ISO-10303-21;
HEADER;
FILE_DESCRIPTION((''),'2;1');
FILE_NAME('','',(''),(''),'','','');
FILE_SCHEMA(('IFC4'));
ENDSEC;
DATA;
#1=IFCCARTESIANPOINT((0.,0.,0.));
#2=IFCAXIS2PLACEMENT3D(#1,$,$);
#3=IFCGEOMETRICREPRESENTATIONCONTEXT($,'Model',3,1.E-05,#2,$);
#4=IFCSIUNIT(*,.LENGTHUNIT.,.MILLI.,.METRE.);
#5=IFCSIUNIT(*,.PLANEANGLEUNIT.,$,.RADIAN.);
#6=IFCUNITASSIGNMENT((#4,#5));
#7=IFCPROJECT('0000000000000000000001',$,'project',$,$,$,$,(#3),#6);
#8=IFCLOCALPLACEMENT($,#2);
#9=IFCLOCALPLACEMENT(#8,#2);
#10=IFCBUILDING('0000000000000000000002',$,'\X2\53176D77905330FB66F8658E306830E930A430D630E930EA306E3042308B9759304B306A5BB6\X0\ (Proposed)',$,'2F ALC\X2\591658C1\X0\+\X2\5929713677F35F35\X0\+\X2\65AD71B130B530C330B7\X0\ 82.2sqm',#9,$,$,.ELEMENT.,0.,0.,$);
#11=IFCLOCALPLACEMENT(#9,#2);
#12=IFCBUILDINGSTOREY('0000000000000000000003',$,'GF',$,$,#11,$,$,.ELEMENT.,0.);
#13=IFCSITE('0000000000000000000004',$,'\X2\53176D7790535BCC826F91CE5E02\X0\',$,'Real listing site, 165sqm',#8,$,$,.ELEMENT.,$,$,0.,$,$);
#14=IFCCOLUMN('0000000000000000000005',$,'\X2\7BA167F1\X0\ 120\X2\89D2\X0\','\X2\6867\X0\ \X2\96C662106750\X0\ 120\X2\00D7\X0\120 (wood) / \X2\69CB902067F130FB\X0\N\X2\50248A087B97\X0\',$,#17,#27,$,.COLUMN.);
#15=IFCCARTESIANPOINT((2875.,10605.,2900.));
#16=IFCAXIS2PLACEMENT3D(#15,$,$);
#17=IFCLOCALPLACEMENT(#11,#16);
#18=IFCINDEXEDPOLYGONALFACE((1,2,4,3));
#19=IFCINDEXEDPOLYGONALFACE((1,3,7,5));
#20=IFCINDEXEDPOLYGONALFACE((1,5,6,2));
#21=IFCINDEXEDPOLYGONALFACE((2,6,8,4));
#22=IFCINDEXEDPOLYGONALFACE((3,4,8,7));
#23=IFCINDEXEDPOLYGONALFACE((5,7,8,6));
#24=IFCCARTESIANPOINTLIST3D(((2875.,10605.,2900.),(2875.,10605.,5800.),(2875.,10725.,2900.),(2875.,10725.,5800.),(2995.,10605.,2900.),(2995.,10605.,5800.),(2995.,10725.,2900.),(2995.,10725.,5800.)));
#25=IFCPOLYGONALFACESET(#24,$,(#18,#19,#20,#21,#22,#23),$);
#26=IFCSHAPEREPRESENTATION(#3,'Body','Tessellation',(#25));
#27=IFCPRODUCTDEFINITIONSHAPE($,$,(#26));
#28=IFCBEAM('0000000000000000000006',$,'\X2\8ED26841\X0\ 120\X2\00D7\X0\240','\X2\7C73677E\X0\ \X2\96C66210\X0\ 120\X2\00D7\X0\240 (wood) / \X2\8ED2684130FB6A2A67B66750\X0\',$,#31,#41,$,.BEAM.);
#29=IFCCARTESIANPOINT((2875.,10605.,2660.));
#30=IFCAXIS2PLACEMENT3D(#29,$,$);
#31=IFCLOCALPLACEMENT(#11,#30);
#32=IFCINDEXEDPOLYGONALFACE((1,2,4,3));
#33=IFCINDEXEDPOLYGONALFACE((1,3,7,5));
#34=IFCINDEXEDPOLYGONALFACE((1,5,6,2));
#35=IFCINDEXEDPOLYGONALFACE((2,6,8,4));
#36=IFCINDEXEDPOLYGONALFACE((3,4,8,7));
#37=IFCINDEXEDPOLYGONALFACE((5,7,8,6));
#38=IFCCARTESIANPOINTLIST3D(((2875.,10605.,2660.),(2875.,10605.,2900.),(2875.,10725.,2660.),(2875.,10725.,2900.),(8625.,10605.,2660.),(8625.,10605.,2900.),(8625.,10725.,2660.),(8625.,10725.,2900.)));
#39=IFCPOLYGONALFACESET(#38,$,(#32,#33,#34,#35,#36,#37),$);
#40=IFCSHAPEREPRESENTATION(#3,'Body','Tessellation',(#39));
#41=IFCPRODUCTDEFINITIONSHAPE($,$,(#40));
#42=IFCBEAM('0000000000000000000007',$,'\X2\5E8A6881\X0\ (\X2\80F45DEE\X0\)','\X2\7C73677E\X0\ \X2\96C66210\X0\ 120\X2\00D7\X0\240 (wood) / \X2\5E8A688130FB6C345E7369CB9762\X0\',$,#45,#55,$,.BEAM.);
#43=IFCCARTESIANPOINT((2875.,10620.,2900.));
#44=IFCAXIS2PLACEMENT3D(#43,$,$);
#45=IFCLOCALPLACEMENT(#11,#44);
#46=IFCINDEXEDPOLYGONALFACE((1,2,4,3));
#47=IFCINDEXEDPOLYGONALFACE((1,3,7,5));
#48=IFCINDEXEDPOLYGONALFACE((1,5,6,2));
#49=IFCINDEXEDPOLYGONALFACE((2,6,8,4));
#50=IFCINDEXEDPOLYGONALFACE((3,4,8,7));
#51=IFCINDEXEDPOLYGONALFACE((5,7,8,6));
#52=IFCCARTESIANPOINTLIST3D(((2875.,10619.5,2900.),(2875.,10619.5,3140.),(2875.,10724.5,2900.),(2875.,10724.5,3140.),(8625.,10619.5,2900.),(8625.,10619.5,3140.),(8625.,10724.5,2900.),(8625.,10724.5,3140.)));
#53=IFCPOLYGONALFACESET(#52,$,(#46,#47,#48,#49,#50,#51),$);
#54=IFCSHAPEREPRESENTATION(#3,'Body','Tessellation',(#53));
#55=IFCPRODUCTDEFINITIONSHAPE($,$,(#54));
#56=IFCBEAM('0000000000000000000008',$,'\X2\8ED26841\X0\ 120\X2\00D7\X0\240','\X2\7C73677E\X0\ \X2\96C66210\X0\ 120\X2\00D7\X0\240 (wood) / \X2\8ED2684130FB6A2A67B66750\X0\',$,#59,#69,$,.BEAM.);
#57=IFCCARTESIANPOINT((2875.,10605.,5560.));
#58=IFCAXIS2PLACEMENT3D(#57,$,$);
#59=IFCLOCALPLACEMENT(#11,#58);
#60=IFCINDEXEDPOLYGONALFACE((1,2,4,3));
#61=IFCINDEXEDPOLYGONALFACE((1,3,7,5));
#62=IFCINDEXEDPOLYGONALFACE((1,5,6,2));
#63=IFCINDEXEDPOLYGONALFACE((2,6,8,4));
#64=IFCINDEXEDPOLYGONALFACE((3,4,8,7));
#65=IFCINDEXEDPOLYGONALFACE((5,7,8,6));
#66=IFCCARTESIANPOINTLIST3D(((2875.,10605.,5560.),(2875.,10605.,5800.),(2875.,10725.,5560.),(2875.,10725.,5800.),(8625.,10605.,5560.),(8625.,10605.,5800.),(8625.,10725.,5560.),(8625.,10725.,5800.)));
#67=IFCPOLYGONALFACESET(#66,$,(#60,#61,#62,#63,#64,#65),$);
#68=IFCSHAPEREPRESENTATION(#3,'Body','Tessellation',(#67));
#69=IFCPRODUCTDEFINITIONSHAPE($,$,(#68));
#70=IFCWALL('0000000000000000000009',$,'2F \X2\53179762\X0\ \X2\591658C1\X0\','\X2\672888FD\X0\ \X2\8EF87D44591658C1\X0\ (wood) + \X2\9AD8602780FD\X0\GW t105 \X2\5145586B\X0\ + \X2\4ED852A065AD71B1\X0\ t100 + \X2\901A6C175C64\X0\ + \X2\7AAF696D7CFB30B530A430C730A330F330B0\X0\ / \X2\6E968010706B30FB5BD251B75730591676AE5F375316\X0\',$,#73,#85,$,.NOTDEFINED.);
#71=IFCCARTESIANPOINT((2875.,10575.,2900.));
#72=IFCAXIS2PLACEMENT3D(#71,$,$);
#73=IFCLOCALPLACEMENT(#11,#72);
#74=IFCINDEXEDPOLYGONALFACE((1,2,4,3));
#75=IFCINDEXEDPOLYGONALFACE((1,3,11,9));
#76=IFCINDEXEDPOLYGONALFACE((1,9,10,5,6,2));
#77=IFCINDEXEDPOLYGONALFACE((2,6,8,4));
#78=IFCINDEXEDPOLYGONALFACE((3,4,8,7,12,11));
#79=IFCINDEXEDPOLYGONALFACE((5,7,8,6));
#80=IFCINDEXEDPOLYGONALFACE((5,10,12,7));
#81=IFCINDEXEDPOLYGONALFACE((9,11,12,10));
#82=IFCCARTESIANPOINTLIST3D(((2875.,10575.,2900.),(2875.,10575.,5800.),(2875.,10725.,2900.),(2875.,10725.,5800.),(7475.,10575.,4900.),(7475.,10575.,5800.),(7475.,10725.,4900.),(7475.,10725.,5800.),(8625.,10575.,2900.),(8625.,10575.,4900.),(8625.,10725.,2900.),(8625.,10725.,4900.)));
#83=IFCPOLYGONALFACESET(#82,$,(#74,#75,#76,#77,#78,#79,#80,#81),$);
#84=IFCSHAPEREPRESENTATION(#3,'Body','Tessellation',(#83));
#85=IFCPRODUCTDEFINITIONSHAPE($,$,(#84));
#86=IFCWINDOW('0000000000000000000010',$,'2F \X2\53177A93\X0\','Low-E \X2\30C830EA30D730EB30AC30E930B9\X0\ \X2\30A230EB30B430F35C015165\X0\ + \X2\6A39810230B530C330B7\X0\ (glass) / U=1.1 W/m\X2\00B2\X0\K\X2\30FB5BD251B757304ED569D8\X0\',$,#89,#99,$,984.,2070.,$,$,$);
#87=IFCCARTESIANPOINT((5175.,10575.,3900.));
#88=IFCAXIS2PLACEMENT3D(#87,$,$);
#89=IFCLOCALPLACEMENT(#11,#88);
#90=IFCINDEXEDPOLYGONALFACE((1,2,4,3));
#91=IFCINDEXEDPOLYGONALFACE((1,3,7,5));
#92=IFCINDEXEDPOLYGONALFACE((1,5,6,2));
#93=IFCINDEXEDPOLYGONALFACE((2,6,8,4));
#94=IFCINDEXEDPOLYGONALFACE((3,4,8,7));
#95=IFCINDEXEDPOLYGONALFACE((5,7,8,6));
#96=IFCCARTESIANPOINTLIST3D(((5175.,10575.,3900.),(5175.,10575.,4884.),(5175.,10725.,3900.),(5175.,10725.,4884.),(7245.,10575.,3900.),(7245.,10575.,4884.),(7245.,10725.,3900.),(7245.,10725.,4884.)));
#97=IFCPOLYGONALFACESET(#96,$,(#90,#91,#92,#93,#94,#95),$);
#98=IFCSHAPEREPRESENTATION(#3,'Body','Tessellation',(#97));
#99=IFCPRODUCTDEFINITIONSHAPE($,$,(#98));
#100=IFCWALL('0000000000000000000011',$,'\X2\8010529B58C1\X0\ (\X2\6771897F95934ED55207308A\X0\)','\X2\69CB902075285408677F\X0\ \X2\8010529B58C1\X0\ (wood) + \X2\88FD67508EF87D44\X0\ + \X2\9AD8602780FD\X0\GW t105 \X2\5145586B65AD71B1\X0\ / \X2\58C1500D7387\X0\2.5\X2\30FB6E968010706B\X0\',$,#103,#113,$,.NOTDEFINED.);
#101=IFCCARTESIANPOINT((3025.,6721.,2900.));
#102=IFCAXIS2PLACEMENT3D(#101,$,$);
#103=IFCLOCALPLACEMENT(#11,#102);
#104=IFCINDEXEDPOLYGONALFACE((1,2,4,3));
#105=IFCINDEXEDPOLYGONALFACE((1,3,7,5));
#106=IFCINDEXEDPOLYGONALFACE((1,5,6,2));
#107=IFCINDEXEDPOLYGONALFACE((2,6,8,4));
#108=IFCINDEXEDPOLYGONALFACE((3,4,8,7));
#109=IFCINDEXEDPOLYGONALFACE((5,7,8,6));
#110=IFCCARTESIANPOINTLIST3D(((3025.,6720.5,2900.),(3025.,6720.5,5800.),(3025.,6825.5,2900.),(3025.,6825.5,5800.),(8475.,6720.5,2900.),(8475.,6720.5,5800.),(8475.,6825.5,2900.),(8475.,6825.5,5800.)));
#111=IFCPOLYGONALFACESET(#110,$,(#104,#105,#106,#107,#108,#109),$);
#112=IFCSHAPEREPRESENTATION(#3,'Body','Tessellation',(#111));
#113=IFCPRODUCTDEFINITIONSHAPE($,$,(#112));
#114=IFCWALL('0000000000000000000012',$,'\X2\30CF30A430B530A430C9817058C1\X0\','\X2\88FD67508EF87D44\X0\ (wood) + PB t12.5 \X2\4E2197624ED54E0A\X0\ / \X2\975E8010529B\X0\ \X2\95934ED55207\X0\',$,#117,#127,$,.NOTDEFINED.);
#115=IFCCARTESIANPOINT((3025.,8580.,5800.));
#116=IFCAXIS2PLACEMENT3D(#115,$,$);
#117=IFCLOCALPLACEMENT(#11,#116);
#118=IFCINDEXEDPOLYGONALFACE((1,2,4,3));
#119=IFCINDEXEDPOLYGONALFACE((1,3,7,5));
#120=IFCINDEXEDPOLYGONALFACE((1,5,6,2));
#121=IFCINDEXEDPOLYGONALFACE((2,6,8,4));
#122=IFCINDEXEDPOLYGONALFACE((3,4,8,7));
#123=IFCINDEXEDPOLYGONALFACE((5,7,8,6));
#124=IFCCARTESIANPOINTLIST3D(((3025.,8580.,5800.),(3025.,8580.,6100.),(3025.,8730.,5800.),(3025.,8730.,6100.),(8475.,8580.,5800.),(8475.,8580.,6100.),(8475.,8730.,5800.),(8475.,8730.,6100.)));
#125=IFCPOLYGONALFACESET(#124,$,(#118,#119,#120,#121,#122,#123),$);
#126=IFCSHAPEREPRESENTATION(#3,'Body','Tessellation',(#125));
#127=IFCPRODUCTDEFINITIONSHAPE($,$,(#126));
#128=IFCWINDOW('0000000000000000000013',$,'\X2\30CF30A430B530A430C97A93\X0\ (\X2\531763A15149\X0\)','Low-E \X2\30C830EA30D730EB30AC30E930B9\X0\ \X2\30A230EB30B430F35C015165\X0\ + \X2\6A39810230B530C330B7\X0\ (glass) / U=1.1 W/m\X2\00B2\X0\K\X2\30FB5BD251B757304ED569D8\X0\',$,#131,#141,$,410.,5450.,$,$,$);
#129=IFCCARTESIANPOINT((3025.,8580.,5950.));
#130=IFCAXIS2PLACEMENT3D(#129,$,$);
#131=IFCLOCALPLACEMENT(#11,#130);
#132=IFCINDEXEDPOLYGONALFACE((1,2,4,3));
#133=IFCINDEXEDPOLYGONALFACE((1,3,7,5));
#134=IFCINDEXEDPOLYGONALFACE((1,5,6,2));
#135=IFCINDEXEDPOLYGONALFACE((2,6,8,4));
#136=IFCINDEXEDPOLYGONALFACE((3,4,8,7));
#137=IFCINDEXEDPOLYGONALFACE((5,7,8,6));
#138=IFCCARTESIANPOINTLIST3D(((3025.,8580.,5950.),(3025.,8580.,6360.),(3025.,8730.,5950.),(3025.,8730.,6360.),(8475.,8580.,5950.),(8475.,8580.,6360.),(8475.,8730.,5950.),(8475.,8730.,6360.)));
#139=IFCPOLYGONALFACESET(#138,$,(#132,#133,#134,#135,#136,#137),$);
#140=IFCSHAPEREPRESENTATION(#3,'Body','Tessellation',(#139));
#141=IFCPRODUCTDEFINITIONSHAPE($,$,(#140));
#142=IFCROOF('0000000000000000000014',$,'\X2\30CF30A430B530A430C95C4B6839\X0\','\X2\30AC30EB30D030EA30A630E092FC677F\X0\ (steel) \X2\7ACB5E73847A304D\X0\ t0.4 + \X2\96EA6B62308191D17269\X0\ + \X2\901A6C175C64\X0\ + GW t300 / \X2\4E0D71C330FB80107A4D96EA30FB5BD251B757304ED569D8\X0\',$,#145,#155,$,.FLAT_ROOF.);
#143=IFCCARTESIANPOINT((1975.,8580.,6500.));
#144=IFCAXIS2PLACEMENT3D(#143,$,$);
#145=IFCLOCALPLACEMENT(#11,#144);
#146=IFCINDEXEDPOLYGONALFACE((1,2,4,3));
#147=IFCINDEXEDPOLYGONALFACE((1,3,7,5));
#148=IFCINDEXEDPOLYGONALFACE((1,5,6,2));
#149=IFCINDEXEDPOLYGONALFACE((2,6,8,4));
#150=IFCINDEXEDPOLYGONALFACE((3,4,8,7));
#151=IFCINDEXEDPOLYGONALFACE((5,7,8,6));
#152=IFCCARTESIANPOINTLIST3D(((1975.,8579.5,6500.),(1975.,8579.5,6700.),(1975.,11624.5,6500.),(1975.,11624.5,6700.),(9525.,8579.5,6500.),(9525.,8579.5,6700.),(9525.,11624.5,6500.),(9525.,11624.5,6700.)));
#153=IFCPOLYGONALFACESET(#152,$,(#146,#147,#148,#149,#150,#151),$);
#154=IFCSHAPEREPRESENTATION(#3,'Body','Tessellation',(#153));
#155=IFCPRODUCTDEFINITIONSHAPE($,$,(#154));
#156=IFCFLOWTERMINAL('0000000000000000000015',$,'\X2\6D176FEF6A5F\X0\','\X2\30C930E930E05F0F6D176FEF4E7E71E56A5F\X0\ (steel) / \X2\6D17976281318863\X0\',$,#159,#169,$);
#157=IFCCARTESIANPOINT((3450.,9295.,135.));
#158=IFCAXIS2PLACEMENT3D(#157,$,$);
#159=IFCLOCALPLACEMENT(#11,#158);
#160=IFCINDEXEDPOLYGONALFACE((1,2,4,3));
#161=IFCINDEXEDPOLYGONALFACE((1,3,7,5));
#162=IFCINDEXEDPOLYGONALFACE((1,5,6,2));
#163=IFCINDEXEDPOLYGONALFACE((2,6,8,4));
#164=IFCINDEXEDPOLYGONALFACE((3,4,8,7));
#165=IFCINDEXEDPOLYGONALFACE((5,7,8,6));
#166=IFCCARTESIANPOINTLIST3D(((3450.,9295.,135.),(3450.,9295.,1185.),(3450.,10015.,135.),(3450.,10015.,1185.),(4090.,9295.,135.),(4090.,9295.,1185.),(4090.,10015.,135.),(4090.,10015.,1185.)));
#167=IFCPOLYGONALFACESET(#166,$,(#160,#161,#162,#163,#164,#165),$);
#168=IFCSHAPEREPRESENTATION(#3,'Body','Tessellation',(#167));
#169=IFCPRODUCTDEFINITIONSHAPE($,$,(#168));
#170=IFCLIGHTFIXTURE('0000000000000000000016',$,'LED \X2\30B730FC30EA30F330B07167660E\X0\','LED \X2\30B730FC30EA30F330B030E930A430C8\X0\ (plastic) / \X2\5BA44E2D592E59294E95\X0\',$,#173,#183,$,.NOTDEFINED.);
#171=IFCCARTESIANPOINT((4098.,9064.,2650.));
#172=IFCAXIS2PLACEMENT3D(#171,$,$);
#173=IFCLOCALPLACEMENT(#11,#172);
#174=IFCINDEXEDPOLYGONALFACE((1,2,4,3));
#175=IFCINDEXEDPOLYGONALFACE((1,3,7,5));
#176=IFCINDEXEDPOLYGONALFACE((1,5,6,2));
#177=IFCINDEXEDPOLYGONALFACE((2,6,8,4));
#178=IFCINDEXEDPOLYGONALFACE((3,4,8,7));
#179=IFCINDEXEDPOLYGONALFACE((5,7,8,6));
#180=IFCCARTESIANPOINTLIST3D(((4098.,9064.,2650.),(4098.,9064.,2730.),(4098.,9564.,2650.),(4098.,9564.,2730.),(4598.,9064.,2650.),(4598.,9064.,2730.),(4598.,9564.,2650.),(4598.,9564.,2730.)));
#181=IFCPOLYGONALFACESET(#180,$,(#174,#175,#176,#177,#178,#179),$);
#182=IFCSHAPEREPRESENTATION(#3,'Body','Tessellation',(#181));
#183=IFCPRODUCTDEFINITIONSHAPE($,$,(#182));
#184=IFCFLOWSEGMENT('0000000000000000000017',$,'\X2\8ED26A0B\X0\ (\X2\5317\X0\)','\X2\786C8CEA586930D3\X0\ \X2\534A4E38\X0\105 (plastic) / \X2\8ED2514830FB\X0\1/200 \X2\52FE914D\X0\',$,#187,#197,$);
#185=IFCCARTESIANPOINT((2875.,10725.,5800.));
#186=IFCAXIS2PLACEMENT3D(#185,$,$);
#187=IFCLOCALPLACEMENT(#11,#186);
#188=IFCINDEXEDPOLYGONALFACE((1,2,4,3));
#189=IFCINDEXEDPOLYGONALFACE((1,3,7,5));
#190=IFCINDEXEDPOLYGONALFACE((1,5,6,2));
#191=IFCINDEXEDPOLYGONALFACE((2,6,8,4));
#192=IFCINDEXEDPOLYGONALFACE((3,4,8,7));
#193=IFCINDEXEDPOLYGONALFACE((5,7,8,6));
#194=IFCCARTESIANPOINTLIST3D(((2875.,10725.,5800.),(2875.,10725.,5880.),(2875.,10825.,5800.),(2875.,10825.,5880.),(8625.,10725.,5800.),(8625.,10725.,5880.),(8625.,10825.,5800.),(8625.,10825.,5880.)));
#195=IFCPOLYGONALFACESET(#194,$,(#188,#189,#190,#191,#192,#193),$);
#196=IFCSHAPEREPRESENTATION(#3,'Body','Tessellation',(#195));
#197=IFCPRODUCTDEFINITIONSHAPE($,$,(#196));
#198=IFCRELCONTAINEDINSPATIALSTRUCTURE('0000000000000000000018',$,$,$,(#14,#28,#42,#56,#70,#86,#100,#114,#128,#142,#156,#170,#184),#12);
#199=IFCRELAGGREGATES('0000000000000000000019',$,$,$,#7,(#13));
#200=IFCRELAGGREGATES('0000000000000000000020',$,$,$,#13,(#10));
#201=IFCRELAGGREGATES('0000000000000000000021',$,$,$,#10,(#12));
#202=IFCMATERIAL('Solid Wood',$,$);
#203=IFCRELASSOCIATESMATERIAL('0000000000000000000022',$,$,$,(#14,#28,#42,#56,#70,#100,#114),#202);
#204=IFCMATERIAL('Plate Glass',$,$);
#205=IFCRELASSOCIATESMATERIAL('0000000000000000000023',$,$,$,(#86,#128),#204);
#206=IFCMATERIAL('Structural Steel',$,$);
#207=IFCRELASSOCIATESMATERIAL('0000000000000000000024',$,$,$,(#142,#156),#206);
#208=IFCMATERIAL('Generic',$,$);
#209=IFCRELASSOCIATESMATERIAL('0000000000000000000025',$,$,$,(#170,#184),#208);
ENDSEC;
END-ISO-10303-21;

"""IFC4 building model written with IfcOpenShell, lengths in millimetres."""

from ifc_helpers import new_model, si_unit, frame, frame_2d, origin, place, context, project, spatial, rectangle, extrude, material, element, fill, save


model = new_model("IFC4")

# Units and contexts
model_context = context("Model", 3, precision=1e-05, world=origin())
ifc_project = project(units=[si_unit("LENGTHUNIT", "METRE", prefix="MILLI"), si_unit("PLANEANGLEUNIT", "RADIAN")], contexts=[model_context])

# Site, building, storey
site_placement = place(None, origin())
site = spatial("IfcSite", under=ifc_project, at=site_placement, Name="北海道富良野市", ObjectType="Real listing site, 165sqm", CompositionType="ELEMENT", RefElevation=0.0)
building_placement = place(site_placement, origin())
building = spatial("IfcBuilding", under=site, at=building_placement, Name="北海道・書斎とライブラリのある静かな家 (Proposed)", ObjectType="2F ALC外壁+天然石張+断熱サッシ 82.2sqm", CompositionType="ELEMENT", ElevationOfRefHeight=0.0, ElevationOfTerrain=0.0)
storey_placement = place(building_placement, origin())
storey = spatial("IfcBuildingStorey", under=building, at=storey_placement, Name="GF", CompositionType="ELEMENT", Elevation=0.0)

# Column
ifc_material_1 = material(Name="Solid Wood")
column_1_placement = place(storey_placement, frame((2875.0, 10605.0, 2900.0)))
element("IfcColumn", 1, at=column_1_placement, inside=storey, material=ifc_material_1, Name="管柱 120角", Description="桧 集成材 120×120 (wood) / 構造柱・N値計算", PredefinedType="COLUMN", context=model_context, shape_type="SweptSolid", body=[
    extrude(rectangle(XDim=120.0, YDim=120.0, at=frame_2d((60.0, 60.0))), frame((2875.0, 10605.0, 2900.0)), (0.0, 0.0, 1.0), 2900.0),
])

# Beams
beam_1_placement = place(storey_placement, frame((2875.0, 10605.0, 2660.0)))
element("IfcBeam", 2, at=beam_1_placement, inside=storey, material=ifc_material_1, Name="軒桁 120×240", Description="米松 集成 120×240 (wood) / 軒桁・横架材", PredefinedType="BEAM", context=model_context, shape_type="SweptSolid", body=[
    extrude(rectangle(XDim=5750.0, YDim=120.0, at=frame_2d((2875.0, 60.0))), frame((2875.0, 10605.0, 2660.0)), (0.0, 0.0, 1.0), 240.0),
])
beam_2_placement = place(storey_placement, frame((2875.0, 10620.0, 2900.0)))
element("IfcBeam", 3, at=beam_2_placement, inside=storey, material=ifc_material_1, Name="床梁 (胴差)", Description="米松 集成 120×240 (wood) / 床梁・水平構面", PredefinedType="BEAM", context=model_context, shape_type="SweptSolid", body=[
    extrude(rectangle(XDim=5750.0, YDim=105.0, at=frame_2d((2875.0, 52.0))), frame((2875.0, 10620.0, 2900.0)), (0.0, 0.0, 1.0), 240.0),
])
beam_3_placement = place(storey_placement, frame((2875.0, 10605.0, 5560.0)))
element("IfcBeam", 4, at=beam_3_placement, inside=storey, material=ifc_material_1, Name="軒桁 120×240", Description="米松 集成 120×240 (wood) / 軒桁・横架材", PredefinedType="BEAM", context=model_context, shape_type="SweptSolid", body=[
    extrude(rectangle(XDim=5750.0, YDim=120.0, at=frame_2d((2875.0, 60.0))), frame((2875.0, 10605.0, 5560.0)), (0.0, 0.0, 1.0), 240.0),
])

# Wall, opening, window
wall_1_placement = place(storey_placement, frame((2875.0, 10575.0, 2900.0)))
wall_1 = element("IfcWall", 5, at=wall_1_placement, inside=storey, material=ifc_material_1, Name="2F 北面 外壁", Description="木製 軸組外壁 (wood) + 高性能GW t105 充填 + 付加断熱 t100 + 通気層 + 窯業系サイディング / 準耐火・寒冷地外皮強化", PredefinedType="NOTDEFINED", context=model_context, shape_type="SweptSolid", body=[
    extrude(rectangle(XDim=5750.0, YDim=150.0, at=frame_2d((2875.0, 75.0))), frame((2875.0, 10575.0, 2900.0)), (0.0, 0.0, 1.0), 2900.0),
])
opening_1_placement = place(storey_placement, frame((5175.0, 10575.0, 3900.0)))
opening_1 = element("IfcOpeningElement", 6, at=opening_1_placement, cuts=wall_1, PredefinedType="NOTDEFINED", context=model_context, shape_type="SweptSolid", body=[
    extrude(rectangle(XDim=2070.0, YDim=150.0, at=frame_2d((1035.0, 75.0))), frame((5175.0, 10575.0, 3900.0)), (0.0, 0.0, 1.0), 984.0),
])
ifc_material_2 = material(Name="Plate Glass")
window_1_placement = place(storey_placement, frame((5175.0, 10575.0, 3900.0)))
window_1 = element("IfcWindow", 7, at=window_1_placement, inside=storey, material=ifc_material_2, Name="2F 北窓", Description="Low-E トリプルガラス アルゴン封入 + 樹脂サッシ (glass) / U=1.1 W/m²K・寒冷地仕様", OverallHeight=984.0, OverallWidth=2070.0, context=model_context, shape_type="SweptSolid", body=[
    extrude(rectangle(XDim=2070.0, YDim=150.0, at=frame_2d((1035.0, 75.0))), frame((5175.0, 10575.0, 3900.0)), (0.0, 0.0, 1.0), 984.0),
])
fill(opening_1, window_1)

# Wall
wall_2_placement = place(storey_placement, frame((3025.0, 6721.0, 2900.0)))
element("IfcWall", 8, at=wall_2_placement, inside=storey, material=ifc_material_1, Name="耐力壁 (東西間仕切り)", Description="構造用合板 耐力壁 (wood) + 製材軸組 + 高性能GW t105 充填断熱 / 壁倍率2.5・準耐火", PredefinedType="NOTDEFINED", context=model_context, shape_type="SweptSolid", body=[
    extrude(rectangle(XDim=5450.0, YDim=105.0, at=frame_2d((2725.0, 52.0))), frame((3025.0, 6721.0, 2900.0)), (0.0, 0.0, 1.0), 2900.0),
])

# Wall, opening, window
wall_3_placement = place(storey_placement, frame((3025.0, 8580.0, 5800.0)))
wall_3 = element("IfcWall", 9, at=wall_3_placement, inside=storey, material=ifc_material_1, Name="ハイサイド腰壁", Description="製材軸組 (wood) + PB t12.5 両面仕上 / 非耐力 間仕切", PredefinedType="NOTDEFINED", context=model_context, shape_type="SweptSolid", body=[
    extrude(rectangle(XDim=5450.0, YDim=150.0, at=frame_2d((2725.0, 75.0))), frame((3025.0, 8580.0, 5800.0)), (0.0, 0.0, 1.0), 700.0),
])
opening_2_placement = place(storey_placement, frame((3025.0, 8580.0, 5950.0)))
opening_2 = element("IfcOpeningElement", 10, at=opening_2_placement, cuts=wall_3, PredefinedType="NOTDEFINED", context=model_context, shape_type="SweptSolid", body=[
    extrude(rectangle(XDim=5450.0, YDim=150.0, at=frame_2d((2725.0, 75.0))), frame((3025.0, 8580.0, 5950.0)), (0.0, 0.0, 1.0), 410.0),
])
window_2_placement = place(storey_placement, frame((3025.0, 8580.0, 5950.0)))
window_2 = element("IfcWindow", 11, at=window_2_placement, inside=storey, material=ifc_material_2, Name="ハイサイド窓 (北採光)", Description="Low-E トリプルガラス アルゴン封入 + 樹脂サッシ (glass) / U=1.1 W/m²K・寒冷地仕様", OverallHeight=410.0, OverallWidth=5450.0, context=model_context, shape_type="SweptSolid", body=[
    extrude(rectangle(XDim=5450.0, YDim=150.0, at=frame_2d((2725.0, 75.0))), frame((3025.0, 8580.0, 5950.0)), (0.0, 0.0, 1.0), 410.0),
])
fill(opening_2, window_2)

# Roof
ifc_material_3 = material(Name="Structural Steel")
roof_placement = place(storey_placement, frame((1975.0, 8580.0, 6500.0)))
element("IfcRoof", 12, at=roof_placement, inside=storey, material=ifc_material_3, Name="ハイサイド屋根", Description="ガルバリウム鋼板 (steel) 立平葺き t0.4 + 雪止め金物 + 通気層 + GW t300 / 不燃・耐積雪・寒冷地仕様", PredefinedType="FLAT_ROOF", context=model_context, shape_type="SweptSolid", body=[
    extrude(rectangle(XDim=7550.0, YDim=3045.0, at=frame_2d((3775.0, 1522.0))), frame((1975.0, 8580.0, 6500.0)), (0.0, 0.0, 1.0), 200.0),
])

# Flow terminal
flow_terminal_placement = place(storey_placement, frame((3450.0, 9295.0, 135.0)))
element("IfcFlowTerminal", 13, at=flow_terminal_placement, inside=storey, material=ifc_material_3, Name="洗濯機", Description="ドラム式洗濯乾燥機 (steel) / 洗面脱衣", context=model_context, shape_type="SweptSolid", body=[
    extrude(rectangle(XDim=640.0, YDim=720.0, at=frame_2d((320.0, 360.0))), frame((3450.0, 9295.0, 135.0)), (0.0, 0.0, 1.0), 1050.0),
])

# Light fixture
ifc_material_4 = material(Name="Generic")
light_fixture_placement = place(storey_placement, frame((4098.0, 9064.0, 2650.0)))
element("IfcLightFixture", 14, at=light_fixture_placement, inside=storey, material=ifc_material_4, Name="LED シーリング照明", Description="LED シーリングライト (plastic) / 室中央天井", PredefinedType="NOTDEFINED", context=model_context, shape_type="SweptSolid", body=[
    extrude(rectangle(XDim=500.0, YDim=500.0, at=frame_2d((250.0, 250.0))), frame((4098.0, 9064.0, 2650.0)), (0.0, 0.0, 1.0), 80.0),
])

# Flow segment
flow_segment_placement = place(storey_placement, frame((2875.0, 10725.0, 5800.0)))
element("IfcFlowSegment", 15, at=flow_segment_placement, inside=storey, material=ifc_material_4, Name="軒樋 (北)", Description="硬質塩ビ 半丸105 (plastic) / 軒先・1/200 勾配", context=model_context, shape_type="SweptSolid", body=[
    extrude(rectangle(XDim=5750.0, YDim=100.0, at=frame_2d((2875.0, 50.0))), frame((2875.0, 10725.0, 5800.0)), (0.0, 0.0, 1.0), 80.0),
])

save(model, "model.ifc")
